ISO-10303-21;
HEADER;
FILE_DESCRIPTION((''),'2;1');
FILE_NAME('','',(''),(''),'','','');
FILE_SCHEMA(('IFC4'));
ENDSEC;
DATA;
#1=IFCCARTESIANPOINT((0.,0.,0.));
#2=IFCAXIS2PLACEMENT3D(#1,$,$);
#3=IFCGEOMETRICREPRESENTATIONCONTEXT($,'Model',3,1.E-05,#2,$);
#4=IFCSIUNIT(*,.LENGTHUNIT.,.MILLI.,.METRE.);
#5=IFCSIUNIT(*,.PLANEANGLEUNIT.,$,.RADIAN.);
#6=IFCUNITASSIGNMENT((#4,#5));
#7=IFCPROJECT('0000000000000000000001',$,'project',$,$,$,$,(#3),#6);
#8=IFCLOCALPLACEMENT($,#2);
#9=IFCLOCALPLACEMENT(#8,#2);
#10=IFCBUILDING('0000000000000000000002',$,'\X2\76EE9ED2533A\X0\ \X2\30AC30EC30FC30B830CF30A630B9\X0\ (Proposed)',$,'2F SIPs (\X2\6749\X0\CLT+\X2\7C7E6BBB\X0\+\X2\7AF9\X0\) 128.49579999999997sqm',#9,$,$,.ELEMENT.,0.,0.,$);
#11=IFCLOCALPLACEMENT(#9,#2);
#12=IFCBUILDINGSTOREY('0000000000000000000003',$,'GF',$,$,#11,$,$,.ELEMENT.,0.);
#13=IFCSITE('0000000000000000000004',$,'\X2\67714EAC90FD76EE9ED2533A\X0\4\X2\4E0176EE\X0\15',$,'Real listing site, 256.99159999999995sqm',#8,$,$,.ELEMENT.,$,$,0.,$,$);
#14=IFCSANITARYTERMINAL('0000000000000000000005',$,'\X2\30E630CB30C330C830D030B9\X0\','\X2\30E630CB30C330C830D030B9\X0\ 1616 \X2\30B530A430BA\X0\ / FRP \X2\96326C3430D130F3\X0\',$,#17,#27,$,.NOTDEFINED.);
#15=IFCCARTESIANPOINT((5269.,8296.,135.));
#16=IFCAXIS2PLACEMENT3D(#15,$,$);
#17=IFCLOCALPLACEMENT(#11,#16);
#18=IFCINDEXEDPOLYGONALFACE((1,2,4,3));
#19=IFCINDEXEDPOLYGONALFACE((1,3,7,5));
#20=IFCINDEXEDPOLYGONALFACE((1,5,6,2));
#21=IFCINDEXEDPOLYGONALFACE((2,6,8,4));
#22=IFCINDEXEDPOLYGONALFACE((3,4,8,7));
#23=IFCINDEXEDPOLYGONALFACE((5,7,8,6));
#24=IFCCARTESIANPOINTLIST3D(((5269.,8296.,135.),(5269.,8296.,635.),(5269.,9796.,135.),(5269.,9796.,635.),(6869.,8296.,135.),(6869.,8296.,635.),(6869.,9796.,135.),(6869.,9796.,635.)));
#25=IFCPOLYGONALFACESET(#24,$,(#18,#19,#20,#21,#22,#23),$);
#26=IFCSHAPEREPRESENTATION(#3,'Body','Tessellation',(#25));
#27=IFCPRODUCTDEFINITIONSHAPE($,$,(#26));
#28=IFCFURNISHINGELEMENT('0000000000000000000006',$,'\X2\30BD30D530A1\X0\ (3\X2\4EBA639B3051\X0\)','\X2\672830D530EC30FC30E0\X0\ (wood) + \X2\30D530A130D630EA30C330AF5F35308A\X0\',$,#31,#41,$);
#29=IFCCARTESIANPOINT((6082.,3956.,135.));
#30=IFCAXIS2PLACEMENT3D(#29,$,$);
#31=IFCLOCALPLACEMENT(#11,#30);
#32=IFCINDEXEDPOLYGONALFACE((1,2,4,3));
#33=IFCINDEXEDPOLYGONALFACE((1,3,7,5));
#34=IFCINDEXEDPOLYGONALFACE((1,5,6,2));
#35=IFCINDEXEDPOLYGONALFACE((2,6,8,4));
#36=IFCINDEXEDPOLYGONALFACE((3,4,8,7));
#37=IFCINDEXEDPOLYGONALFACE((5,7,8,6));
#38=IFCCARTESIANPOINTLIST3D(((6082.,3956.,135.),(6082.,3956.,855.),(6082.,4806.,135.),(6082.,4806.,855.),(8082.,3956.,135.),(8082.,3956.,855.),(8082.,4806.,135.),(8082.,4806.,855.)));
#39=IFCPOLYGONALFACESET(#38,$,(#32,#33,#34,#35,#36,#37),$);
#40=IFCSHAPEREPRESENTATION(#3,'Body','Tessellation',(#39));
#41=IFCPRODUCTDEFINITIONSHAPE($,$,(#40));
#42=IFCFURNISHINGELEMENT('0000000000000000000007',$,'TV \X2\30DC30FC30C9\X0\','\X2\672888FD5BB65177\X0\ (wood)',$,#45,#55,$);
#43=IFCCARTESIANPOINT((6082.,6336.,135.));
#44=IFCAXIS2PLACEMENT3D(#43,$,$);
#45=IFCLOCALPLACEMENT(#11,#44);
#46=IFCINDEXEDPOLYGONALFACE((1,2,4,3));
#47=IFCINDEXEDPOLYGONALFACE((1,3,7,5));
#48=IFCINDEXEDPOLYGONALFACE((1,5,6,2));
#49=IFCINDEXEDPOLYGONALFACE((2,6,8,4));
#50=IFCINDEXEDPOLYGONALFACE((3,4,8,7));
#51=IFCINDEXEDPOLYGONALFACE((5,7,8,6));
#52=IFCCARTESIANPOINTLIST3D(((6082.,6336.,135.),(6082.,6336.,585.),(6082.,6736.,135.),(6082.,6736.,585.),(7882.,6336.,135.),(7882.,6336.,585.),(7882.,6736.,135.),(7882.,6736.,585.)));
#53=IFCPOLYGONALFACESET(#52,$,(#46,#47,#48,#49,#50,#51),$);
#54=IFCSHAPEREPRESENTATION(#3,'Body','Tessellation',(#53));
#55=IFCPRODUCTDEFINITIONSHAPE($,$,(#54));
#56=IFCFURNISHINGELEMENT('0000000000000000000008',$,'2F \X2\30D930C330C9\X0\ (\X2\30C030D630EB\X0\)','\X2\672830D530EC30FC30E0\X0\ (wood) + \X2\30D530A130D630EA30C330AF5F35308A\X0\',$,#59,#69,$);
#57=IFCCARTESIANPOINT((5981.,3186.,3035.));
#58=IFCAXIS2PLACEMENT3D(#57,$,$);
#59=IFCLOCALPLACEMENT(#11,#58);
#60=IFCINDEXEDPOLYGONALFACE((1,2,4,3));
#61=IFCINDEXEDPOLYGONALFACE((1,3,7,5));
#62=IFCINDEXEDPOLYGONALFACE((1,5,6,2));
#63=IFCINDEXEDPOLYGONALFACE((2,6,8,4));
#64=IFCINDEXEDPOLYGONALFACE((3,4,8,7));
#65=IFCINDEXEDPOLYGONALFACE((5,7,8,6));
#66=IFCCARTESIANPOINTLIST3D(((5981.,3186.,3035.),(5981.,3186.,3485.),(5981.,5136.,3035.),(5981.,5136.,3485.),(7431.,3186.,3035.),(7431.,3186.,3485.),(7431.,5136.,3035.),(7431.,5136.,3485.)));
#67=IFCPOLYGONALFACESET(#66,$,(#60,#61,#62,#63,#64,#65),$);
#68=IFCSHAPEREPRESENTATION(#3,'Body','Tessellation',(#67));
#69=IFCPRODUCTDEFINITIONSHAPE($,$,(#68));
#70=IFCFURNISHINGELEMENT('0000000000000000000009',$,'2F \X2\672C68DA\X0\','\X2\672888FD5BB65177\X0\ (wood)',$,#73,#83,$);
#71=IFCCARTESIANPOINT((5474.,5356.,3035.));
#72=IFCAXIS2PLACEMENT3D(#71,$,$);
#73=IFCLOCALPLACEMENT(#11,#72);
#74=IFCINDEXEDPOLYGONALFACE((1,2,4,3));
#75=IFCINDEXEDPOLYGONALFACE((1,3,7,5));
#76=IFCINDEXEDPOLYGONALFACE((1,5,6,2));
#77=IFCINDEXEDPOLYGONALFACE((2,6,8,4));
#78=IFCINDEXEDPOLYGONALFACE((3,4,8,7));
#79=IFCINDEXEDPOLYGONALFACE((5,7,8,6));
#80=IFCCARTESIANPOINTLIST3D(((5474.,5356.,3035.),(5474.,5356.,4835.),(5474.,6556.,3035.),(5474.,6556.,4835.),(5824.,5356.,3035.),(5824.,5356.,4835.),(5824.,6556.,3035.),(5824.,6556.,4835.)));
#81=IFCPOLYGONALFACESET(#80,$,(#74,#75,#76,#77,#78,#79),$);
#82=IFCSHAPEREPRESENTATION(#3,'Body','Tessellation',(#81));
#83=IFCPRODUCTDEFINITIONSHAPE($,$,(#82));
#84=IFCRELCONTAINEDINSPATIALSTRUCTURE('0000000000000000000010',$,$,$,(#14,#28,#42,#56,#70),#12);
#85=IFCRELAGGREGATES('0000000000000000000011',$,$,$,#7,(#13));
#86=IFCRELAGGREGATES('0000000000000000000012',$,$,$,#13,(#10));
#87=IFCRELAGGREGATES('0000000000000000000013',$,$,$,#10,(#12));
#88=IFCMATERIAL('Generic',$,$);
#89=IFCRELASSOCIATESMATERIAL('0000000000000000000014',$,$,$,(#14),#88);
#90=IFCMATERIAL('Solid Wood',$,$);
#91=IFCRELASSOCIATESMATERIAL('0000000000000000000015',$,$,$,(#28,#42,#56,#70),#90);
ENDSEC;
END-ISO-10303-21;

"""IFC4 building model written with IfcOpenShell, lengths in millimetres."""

from ifc_helpers import new_model, si_unit, frame, frame_2d, origin, place, context, project, spatial, rectangle, extrude, material, element, save


model = new_model("IFC4")

# Units and contexts
model_context = context("Model", 3, precision=1e-05, world=origin())
ifc_project = project(units=[si_unit("LENGTHUNIT", "METRE", prefix="MILLI"), si_unit("PLANEANGLEUNIT", "RADIAN")], contexts=[model_context])

# Site, building, storey
site_placement = place(None, origin())
site = spatial("IfcSite", under=ifc_project, at=site_placement, Name="東京都目黒区4丁目15", ObjectType="Real listing site, 256.99159999999995sqm", CompositionType="ELEMENT", RefElevation=0.0)
building_placement = place(site_placement, origin())
building = spatial("IfcBuilding", under=site, at=building_placement, Name="目黒区 ガレージハウス (Proposed)", ObjectType="2F SIPs (杉CLT+籾殻+竹) 128.49579999999997sqm", CompositionType="ELEMENT", ElevationOfRefHeight=0.0, ElevationOfTerrain=0.0)
storey_placement = place(building_placement, origin())
storey = spatial("IfcBuildingStorey", under=building, at=storey_placement, Name="GF", CompositionType="ELEMENT", Elevation=0.0)

# Shared definitions
ifc_material_1 = material(Name="Solid Wood")

# Sanitary terminal
ifc_material_2 = material(Name="Generic")
sanitary_terminal_placement = place(storey_placement, frame((5269.0, 8296.0, 135.0)))
element("IfcSanitaryTerminal", 1, at=sanitary_terminal_placement, inside=storey, material=ifc_material_2, Name="ユニットバス", Description="ユニットバス 1616 サイズ / FRP 防水パン", PredefinedType="NOTDEFINED", context=model_context, shape_type="SweptSolid", body=[
    extrude(rectangle(XDim=1600.0, YDim=1500.0, at=frame_2d((800.0, 750.0))), frame((5269.0, 8296.0, 135.0)), (0.0, 0.0, 1.0), 500.0),
])

# Furnishing elements
furnishing_1_placement = place(storey_placement, frame((6082.0, 3956.0, 135.0)))
element("IfcFurnishingElement", 2, at=furnishing_1_placement, inside=storey, material=ifc_material_1, Name="ソファ (3人掛け)", Description="木フレーム (wood) + ファブリック張り", context=model_context, shape_type="SweptSolid", body=[
    extrude(rectangle(XDim=2000.0, YDim=850.0, at=frame_2d((1000.0, 425.0))), frame((6082.0, 3956.0, 135.0)), (0.0, 0.0, 1.0), 720.0),
])
furnishing_2_placement = place(storey_placement, frame((6082.0, 6336.0, 135.0)))
element("IfcFurnishingElement", 3, at=furnishing_2_placement, inside=storey, material=ifc_material_1, Name="TV ボード", Description="木製家具 (wood)", context=model_context, shape_type="SweptSolid", body=[
    extrude(rectangle(XDim=1800.0, YDim=400.0, at=frame_2d((900.0, 200.0))), frame((6082.0, 6336.0, 135.0)), (0.0, 0.0, 1.0), 450.0),
])
furnishing_3_placement = place(storey_placement, frame((5981.0, 3186.0, 3035.0)))
element("IfcFurnishingElement", 4, at=furnishing_3_placement, inside=storey, material=ifc_material_1, Name="2F ベッド (ダブル)", Description="木フレーム (wood) + ファブリック張り", context=model_context, shape_type="SweptSolid", body=[
    extrude(rectangle(XDim=1450.0, YDim=1950.0, at=frame_2d((725.0, 975.0))), frame((5981.0, 3186.0, 3035.0)), (0.0, 0.0, 1.0), 450.0),
])
furnishing_4_placement = place(storey_placement, frame((5474.0, 5356.0, 3035.0)))
element("IfcFurnishingElement", 5, at=furnishing_4_placement, inside=storey, material=ifc_material_1, Name="2F 本棚", Description="木製家具 (wood)", context=model_context, shape_type="SweptSolid", body=[
    extrude(rectangle(XDim=350.0, YDim=1200.0, at=frame_2d((175.0, 600.0))), frame((5474.0, 5356.0, 3035.0)), (0.0, 0.0, 1.0), 1800.0),
])

save(model, "model.ifc")
